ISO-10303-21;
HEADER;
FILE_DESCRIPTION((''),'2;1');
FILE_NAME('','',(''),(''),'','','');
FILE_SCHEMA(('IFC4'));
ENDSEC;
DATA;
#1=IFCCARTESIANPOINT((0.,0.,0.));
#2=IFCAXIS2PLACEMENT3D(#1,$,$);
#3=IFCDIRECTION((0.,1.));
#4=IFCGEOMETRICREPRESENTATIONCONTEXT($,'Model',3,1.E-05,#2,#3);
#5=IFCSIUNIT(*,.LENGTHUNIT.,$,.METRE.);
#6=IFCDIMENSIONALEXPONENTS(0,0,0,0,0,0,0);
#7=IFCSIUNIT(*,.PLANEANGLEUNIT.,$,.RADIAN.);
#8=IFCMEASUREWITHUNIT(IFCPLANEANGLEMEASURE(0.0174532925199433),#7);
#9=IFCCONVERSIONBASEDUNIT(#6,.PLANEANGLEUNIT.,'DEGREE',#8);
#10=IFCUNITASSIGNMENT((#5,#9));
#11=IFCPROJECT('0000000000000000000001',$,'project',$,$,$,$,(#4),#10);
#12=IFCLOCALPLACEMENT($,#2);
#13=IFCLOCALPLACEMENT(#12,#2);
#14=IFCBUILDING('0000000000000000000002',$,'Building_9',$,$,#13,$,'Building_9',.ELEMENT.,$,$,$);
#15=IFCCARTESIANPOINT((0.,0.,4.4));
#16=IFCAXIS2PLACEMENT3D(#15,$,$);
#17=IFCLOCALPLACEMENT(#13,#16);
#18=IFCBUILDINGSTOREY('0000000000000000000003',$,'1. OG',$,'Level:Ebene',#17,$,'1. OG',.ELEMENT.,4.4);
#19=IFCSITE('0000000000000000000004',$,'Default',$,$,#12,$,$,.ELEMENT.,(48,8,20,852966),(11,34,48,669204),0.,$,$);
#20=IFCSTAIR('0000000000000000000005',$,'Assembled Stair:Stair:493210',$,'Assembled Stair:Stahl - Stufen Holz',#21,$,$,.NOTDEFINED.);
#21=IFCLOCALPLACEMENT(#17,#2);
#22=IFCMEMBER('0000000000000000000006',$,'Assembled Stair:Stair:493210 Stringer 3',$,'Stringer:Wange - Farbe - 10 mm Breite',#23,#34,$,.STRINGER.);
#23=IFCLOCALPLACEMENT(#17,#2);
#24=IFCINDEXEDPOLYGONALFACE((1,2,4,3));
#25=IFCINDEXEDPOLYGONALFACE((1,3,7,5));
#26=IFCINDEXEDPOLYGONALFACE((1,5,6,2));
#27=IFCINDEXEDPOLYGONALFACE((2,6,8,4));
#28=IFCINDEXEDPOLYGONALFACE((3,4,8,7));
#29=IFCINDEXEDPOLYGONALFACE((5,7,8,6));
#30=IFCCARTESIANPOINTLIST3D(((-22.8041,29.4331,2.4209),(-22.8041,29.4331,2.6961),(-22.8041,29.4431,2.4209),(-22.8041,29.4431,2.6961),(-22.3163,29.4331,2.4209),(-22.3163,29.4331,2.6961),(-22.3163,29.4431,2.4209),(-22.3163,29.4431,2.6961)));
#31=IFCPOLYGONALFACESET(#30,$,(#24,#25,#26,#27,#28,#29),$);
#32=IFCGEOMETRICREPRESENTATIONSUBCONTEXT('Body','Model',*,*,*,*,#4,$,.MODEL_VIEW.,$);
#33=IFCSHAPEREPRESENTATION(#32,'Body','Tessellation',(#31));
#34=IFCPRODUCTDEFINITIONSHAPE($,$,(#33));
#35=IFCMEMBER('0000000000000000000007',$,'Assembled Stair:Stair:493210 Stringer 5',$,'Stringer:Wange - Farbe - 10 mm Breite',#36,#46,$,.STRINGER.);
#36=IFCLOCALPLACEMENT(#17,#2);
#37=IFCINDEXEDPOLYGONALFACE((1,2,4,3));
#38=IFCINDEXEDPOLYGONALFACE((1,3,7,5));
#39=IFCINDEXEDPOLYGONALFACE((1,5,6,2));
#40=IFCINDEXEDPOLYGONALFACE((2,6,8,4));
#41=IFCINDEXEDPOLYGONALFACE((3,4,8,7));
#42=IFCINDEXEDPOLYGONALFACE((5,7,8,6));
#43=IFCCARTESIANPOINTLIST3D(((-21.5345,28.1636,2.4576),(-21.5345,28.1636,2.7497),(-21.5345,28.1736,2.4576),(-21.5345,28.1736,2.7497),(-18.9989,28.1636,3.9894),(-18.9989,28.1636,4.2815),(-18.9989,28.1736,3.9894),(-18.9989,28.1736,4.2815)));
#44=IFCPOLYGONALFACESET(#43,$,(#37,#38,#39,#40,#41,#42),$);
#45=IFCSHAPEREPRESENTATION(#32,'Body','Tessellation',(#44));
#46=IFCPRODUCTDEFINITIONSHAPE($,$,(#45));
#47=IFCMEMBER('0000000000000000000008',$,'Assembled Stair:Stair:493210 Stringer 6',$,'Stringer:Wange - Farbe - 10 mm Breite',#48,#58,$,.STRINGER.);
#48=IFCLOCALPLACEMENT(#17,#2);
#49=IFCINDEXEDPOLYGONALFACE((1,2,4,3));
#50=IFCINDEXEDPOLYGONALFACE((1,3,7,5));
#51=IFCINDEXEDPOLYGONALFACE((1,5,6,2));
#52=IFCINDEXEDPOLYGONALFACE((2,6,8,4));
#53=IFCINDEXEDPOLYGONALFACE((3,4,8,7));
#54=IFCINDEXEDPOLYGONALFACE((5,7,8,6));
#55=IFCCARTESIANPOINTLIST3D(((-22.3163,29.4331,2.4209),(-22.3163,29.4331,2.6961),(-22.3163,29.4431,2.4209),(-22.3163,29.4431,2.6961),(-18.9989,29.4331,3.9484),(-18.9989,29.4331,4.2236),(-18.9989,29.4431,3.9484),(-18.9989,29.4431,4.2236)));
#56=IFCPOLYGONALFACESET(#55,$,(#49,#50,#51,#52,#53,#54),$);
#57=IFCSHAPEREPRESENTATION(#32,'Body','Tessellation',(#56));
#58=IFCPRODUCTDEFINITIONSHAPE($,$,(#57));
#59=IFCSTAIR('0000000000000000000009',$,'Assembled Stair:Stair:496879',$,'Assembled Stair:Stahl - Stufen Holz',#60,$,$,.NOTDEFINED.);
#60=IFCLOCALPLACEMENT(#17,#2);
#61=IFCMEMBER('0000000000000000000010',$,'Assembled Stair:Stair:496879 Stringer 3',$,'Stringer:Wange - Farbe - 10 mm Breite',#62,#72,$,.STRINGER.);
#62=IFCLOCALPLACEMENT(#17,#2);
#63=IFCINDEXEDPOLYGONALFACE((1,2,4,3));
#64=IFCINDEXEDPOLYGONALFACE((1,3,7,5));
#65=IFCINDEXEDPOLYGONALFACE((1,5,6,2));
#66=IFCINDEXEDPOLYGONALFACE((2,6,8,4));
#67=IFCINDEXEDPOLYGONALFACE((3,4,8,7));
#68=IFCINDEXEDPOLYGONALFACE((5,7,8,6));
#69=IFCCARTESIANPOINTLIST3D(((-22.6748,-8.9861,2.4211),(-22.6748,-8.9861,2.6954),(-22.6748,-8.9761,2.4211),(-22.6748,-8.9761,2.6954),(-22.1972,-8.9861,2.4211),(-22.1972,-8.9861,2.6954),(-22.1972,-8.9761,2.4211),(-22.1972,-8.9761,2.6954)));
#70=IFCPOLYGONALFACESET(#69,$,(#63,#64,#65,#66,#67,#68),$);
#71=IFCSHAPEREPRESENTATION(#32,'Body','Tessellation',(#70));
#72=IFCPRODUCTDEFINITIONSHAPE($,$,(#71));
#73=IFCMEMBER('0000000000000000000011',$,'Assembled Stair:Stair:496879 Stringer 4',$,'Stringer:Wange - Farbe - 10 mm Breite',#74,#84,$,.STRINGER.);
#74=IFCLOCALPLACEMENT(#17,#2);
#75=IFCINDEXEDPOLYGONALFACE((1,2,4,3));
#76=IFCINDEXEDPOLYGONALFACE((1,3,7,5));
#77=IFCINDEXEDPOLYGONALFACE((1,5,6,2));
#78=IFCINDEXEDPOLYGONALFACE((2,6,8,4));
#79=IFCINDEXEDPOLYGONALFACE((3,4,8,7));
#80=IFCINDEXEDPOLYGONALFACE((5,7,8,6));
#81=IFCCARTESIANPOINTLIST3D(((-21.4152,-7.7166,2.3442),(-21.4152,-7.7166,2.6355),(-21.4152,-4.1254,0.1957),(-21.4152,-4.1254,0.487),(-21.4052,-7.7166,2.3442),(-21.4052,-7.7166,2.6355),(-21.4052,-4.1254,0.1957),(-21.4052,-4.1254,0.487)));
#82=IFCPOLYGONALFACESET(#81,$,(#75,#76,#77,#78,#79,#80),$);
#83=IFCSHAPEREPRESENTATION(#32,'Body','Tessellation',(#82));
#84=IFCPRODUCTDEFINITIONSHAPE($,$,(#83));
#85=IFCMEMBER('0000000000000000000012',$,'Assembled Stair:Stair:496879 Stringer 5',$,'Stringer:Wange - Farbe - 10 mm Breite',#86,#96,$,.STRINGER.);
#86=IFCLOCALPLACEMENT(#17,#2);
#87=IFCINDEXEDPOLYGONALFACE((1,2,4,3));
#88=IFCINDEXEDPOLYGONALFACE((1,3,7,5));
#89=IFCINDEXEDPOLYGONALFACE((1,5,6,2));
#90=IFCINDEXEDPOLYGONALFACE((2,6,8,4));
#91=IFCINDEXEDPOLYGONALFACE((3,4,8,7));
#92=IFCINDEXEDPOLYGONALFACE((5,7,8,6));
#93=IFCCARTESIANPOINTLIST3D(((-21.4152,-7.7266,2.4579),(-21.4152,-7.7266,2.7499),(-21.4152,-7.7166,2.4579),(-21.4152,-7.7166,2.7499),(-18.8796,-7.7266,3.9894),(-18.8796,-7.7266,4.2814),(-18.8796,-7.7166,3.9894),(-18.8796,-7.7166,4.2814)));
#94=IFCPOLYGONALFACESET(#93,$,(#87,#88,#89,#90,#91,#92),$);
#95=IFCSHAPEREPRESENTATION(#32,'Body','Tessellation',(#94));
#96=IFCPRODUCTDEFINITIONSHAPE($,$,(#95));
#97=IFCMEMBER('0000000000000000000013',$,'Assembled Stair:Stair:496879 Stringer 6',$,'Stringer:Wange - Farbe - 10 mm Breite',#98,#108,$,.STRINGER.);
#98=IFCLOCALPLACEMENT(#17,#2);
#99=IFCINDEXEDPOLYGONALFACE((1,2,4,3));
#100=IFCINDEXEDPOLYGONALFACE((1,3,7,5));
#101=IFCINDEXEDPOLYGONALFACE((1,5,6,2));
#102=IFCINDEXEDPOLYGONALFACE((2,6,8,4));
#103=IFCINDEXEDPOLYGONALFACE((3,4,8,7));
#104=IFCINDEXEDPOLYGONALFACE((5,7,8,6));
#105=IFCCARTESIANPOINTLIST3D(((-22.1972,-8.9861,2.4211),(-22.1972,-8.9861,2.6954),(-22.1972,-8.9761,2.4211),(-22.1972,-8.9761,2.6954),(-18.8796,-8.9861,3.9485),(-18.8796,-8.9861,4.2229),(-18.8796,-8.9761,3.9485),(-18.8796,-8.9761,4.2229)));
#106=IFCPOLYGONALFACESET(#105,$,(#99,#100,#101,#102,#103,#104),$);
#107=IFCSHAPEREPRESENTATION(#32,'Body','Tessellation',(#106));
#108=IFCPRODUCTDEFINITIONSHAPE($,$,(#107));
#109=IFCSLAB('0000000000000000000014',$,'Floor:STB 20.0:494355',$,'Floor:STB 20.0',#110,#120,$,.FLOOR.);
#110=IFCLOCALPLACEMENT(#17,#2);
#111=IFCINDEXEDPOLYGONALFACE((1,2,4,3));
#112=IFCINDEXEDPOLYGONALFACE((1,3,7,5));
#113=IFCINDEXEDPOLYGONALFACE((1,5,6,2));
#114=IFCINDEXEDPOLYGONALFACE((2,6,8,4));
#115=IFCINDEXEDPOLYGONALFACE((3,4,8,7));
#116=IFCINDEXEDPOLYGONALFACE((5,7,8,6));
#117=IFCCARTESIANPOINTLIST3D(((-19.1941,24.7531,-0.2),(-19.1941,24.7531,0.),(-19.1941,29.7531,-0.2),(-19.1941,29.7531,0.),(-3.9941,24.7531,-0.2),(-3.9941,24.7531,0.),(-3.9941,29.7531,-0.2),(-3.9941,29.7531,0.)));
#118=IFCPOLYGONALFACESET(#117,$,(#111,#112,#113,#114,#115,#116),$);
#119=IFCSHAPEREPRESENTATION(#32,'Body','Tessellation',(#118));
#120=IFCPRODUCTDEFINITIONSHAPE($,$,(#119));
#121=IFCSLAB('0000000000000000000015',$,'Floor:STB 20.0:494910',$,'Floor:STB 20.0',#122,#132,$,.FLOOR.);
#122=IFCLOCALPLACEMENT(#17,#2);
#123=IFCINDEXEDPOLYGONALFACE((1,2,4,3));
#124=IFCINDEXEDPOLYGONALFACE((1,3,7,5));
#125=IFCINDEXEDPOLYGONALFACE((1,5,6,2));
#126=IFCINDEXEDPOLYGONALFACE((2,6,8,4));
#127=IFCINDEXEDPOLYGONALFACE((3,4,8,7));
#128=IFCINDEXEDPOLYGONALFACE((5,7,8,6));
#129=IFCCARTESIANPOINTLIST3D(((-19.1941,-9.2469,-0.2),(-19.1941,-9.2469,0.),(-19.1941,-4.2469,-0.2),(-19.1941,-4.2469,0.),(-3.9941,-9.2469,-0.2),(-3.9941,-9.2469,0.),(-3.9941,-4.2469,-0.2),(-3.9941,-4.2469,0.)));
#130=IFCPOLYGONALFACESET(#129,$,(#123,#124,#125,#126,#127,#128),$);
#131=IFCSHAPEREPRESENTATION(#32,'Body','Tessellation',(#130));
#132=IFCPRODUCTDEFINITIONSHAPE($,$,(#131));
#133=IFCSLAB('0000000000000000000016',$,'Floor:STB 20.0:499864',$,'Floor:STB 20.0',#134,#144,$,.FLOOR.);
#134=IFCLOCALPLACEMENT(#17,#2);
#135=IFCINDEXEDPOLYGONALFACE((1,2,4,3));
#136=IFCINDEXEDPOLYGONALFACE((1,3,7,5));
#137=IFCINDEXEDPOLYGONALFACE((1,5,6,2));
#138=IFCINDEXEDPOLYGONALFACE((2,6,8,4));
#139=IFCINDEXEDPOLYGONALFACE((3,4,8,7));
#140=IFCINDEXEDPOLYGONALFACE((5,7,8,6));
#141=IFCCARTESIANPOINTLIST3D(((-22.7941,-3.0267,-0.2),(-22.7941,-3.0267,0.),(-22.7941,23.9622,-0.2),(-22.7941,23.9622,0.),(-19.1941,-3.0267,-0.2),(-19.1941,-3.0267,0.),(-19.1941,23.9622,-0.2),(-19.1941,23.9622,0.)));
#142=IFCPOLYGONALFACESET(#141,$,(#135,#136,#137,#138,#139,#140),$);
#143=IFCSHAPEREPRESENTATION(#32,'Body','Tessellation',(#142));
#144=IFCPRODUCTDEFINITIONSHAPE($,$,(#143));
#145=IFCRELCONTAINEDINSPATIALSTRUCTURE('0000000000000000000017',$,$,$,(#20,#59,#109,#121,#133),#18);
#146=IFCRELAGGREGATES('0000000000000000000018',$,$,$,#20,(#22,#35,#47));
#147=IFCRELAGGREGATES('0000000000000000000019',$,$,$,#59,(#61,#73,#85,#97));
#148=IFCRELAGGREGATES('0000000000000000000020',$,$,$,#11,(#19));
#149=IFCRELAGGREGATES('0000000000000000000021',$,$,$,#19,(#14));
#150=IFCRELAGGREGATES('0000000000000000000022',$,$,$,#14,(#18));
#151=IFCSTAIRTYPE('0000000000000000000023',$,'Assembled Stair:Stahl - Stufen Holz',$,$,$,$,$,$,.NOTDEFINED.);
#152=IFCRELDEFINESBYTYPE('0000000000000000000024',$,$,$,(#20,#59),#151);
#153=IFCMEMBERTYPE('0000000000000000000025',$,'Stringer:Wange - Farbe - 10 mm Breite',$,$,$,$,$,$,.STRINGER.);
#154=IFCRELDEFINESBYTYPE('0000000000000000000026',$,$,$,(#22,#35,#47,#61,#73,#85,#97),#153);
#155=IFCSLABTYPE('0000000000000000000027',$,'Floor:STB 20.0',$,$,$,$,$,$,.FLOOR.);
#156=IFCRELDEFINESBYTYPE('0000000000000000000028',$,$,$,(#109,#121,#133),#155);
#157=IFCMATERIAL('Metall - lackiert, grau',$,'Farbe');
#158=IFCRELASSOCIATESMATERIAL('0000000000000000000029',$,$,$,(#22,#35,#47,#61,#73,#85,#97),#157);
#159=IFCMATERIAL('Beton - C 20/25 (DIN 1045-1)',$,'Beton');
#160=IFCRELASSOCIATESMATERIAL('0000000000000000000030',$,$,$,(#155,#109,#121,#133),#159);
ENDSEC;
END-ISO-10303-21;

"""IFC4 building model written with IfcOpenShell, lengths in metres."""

from ifc_helpers import new_model, entity, si_unit, converted_unit, direction, frame, origin, place, context, subcontext, project, spatial, indexed_curve, outline, extrude, material, type_object, element, aggregate, save


model = new_model("IFC4")

# Units and contexts
model_context = context("Model", 3, precision=1e-05, world=origin(), true_north=direction((0.0, 1.0)))
body_context = subcontext(model_context, "Body", "Model", "MODEL_VIEW")
ifc_project = project(units=[si_unit("LENGTHUNIT", "METRE"), converted_unit("PLANEANGLEUNIT", "DEGREE", entity("IfcPlaneAngleMeasure", 0.0174532925199433), si_unit("PLANEANGLEUNIT", "RADIAN"), dimensions=[0, 0, 0, 0, 0, 0, 0])], contexts=[model_context])

# Site, building, storey
site_placement = place(None, origin())
site = spatial("IfcSite", under=ifc_project, at=site_placement, Name="Default", CompositionType="ELEMENT", RefLatitude=(48, 8, 20, 852966), RefLongitude=(11, 34, 48, 669204), RefElevation=0.0)
building_placement = place(site_placement, origin())
building = spatial("IfcBuilding", under=site, at=building_placement, Name="Building_9", LongName="Building_9", CompositionType="ELEMENT")
storey_placement = place(building_placement, frame((0.0, 0.0, 4.4)))
storey = spatial("IfcBuildingStorey", under=building, at=storey_placement, Name="1. OG", ObjectType="Level:Ebene", LongName="1. OG", CompositionType="ELEMENT", Elevation=4.4)

# Stairs, members
stair_type = type_object("IfcStairType", Name="Assembled Stair:Stahl - Stufen Holz", PredefinedType="NOTDEFINED")
stair_1_placement = place(storey_placement, origin())
stair_1 = element("IfcStair", 1, at=stair_1_placement, inside=storey, type_object=stair_type, Name="Assembled Stair:Stair:493210", ObjectType="Assembled Stair:Stahl - Stufen Holz", PredefinedType="NOTDEFINED")
ifc_material_1 = material(Name="Metall - lackiert, grau", Category="Farbe")
member_type = type_object("IfcMemberType", Name="Stringer:Wange - Farbe - 10 mm Breite", PredefinedType="STRINGER")
member_1_placement = place(stair_1_placement, origin())
member_1 = element("IfcMember", 2, at=member_1_placement, type_object=member_type, material=ifc_material_1, Name="Assembled Stair:Stair:493210 Stringer 3", ObjectType="Stringer:Wange - Farbe - 10 mm Breite", PredefinedType="STRINGER", context=body_context, shape_type="SweptSolid", body=[
    extrude(outline(indexed_curve([(-0.2439, -0.005), (0.2439, -0.005), (0.2439, 0.005), (-0.2439, 0.005), (-0.2439, -0.005)], self_intersect=False)), frame((-22.5602, 29.4381, 2.4209)), (0.0, 0.0, 1.0), 0.2752),
])
member_2_placement = place(stair_1_placement, origin())
member_2 = element("IfcMember", 3, at=member_2_placement, type_object=member_type, material=ifc_material_1, Name="Assembled Stair:Stair:493210 Stringer 5", ObjectType="Stringer:Wange - Farbe - 10 mm Breite", PredefinedType="STRINGER", context=body_context, shape_type="SweptSolid", body=[
    extrude(outline(indexed_curve([(-1.4057, -0.125), (1.5567, -0.125), (1.4057, 0.125), (-1.5567, 0.125), (-1.4057, -0.125)], self_intersect=False)), frame((-20.2667, 28.1636, 3.3695), z_axis=(0.0, 1.0, 0.0), x_axis=(0.855931, 0.0, 0.51709)), (0.0, 0.0, 1.0), 0.01),
])
member_3_placement = place(stair_1_placement, origin())
member_3 = element("IfcMember", 4, at=member_3_placement, type_object=member_type, material=ifc_material_1, Name="Assembled Stair:Stair:493210 Stringer 6", ObjectType="Stringer:Wange - Farbe - 10 mm Breite", PredefinedType="STRINGER", context=body_context, shape_type="SweptSolid", body=[
    extrude(outline(indexed_curve([(-1.7685, -0.125), (1.8836, -0.125), (1.7685, 0.125), (-1.8836, 0.125), (-1.7685, -0.125)], self_intersect=False)), frame((-20.6576, 29.4331, 3.3222), z_axis=(0.0, 1.0, 0.0), x_axis=(0.908333, 0.0, 0.418247)), (0.0, 0.0, 1.0), 0.01),
])
stair_2_placement = place(storey_placement, origin())
stair_2 = element("IfcStair", 5, at=stair_2_placement, inside=storey, type_object=stair_type, Name="Assembled Stair:Stair:496879", ObjectType="Assembled Stair:Stahl - Stufen Holz", PredefinedType="NOTDEFINED")
member_4_placement = place(stair_2_placement, origin())
member_4 = element("IfcMember", 6, at=member_4_placement, type_object=member_type, material=ifc_material_1, Name="Assembled Stair:Stair:496879 Stringer 3", ObjectType="Stringer:Wange - Farbe - 10 mm Breite", PredefinedType="STRINGER", context=body_context, shape_type="SweptSolid", body=[
    extrude(outline(indexed_curve([(-0.2388, -0.005), (0.2388, -0.005), (0.2388, 0.005), (-0.2388, 0.005), (-0.2388, -0.005)], self_intersect=False)), frame((-22.436, -8.9811, 2.4211)), (0.0, 0.0, 1.0), 0.2744),
])
member_5_placement = place(stair_2_placement, origin())
member_5 = element("IfcMember", 7, at=member_5_placement, type_object=member_type, material=ifc_material_1, Name="Assembled Stair:Stair:496879 Stringer 4", ObjectType="Stringer:Wange - Farbe - 10 mm Breite", PredefinedType="STRINGER", context=body_context, shape_type="SweptSolid", body=[
    extrude(outline(indexed_curve([(-2.0176, -0.125), (2.1672, -0.125), (2.0176, 0.125), (-2.1672, 0.125), (-2.0176, -0.125)], self_intersect=False)), frame((-21.4152, -5.921, 1.4156), z_axis=(1.0, 0.0, 0.0), x_axis=(0.0, -0.858155, 0.513391)), (0.0, 0.0, 1.0), 0.01),
])
member_6_placement = place(stair_2_placement, origin())
member_6 = element("IfcMember", 8, at=member_6_placement, type_object=member_type, material=ifc_material_1, Name="Assembled Stair:Stair:496879 Stringer 5", ObjectType="Stringer:Wange - Farbe - 10 mm Breite", PredefinedType="STRINGER", context=body_context, shape_type="SweptSolid", body=[
    extrude(outline(indexed_curve([(-1.4056, -0.125), (1.5566, -0.125), (1.4056, 0.125), (-1.5566, 0.125), (-1.4056, -0.125)], self_intersect=False)), frame((-20.1474, -7.7266, 3.3696), z_axis=(0.0, 1.0, 0.0), x_axis=(0.855977, 0.0, 0.517013)), (0.0, 0.0, 1.0), 0.01),
])
member_7_placement = place(stair_2_placement, origin())
member_7 = element("IfcMember", 9, at=member_7_placement, type_object=member_type, material=ifc_material_1, Name="Assembled Stair:Stair:496879 Stringer 6", ObjectType="Stringer:Wange - Farbe - 10 mm Breite", PredefinedType="STRINGER", context=body_context, shape_type="SweptSolid", body=[
    extrude(outline(indexed_curve([(-1.7688, -0.1246), (1.8836, -0.1246), (1.7688, 0.1246), (-1.8836, 0.1246), (-1.7688, -0.1246)], self_intersect=False)), frame((-20.5384, -8.9861, 3.322), z_axis=(0.0, 1.0, 0.0), x_axis=(0.908348, 0.0, 0.418214)), (0.0, 0.0, 1.0), 0.01),
])

# Slabs
ifc_material_2 = material(Name="Beton - C 20/25 (DIN 1045-1)", Category="Beton")
slab_type = type_object("IfcSlabType", Name="Floor:STB 20.0", PredefinedType="FLOOR", material=ifc_material_2)
slab_1_placement = place(storey_placement, origin())
element("IfcSlab", 10, at=slab_1_placement, inside=storey, type_object=slab_type, material=ifc_material_2, Name="Floor:STB 20.0:494355", ObjectType="Floor:STB 20.0", PredefinedType="FLOOR", context=body_context, shape_type="SweptSolid", body=[
    extrude(outline(indexed_curve([(-2.5, -7.6), (2.5, -7.6), (2.5, 7.6), (-2.5, 7.6), (-2.5, -7.6)], self_intersect=False)), frame((-11.5941, 27.2531, 0.0), z_axis=(0.0, 0.0, -1.0), x_axis=(0.0, 1.0, 0.0)), (0.0, 0.0, 1.0), 0.2),
])
slab_2_placement = place(storey_placement, origin())
element("IfcSlab", 11, at=slab_2_placement, inside=storey, type_object=slab_type, material=ifc_material_2, Name="Floor:STB 20.0:494910", ObjectType="Floor:STB 20.0", PredefinedType="FLOOR", context=body_context, shape_type="SweptSolid", body=[
    extrude(outline(indexed_curve([(-2.5, -7.6), (2.5, -7.6), (2.5, 7.6), (-2.5, 7.6), (-2.5, -7.6)], self_intersect=False)), frame((-11.5941, -6.7469, 0.0), z_axis=(0.0, 0.0, -1.0), x_axis=(0.0, 1.0, 0.0)), (0.0, 0.0, 1.0), 0.2),
])
slab_3_placement = place(storey_placement, origin())
element("IfcSlab", 12, at=slab_3_placement, inside=storey, type_object=slab_type, material=ifc_material_2, Name="Floor:STB 20.0:499864", ObjectType="Floor:STB 20.0", PredefinedType="FLOOR", context=body_context, shape_type="SweptSolid", body=[
    extrude(outline(indexed_curve([(-13.4944, -1.8), (13.4944, -1.8), (13.4944, 1.8), (-13.4944, 1.8), (-13.4944, -1.8)], self_intersect=False)), frame((-20.9941, 10.4677, 0.0), z_axis=(0.0, 0.0, -1.0), x_axis=(0.0, 1.0, 0.0)), (0.0, 0.0, 1.0), 0.2),
])

aggregate(stair_1, [member_1, member_2, member_3])
aggregate(stair_2, [member_4, member_5, member_6, member_7])

save(model, "model.ifc")
